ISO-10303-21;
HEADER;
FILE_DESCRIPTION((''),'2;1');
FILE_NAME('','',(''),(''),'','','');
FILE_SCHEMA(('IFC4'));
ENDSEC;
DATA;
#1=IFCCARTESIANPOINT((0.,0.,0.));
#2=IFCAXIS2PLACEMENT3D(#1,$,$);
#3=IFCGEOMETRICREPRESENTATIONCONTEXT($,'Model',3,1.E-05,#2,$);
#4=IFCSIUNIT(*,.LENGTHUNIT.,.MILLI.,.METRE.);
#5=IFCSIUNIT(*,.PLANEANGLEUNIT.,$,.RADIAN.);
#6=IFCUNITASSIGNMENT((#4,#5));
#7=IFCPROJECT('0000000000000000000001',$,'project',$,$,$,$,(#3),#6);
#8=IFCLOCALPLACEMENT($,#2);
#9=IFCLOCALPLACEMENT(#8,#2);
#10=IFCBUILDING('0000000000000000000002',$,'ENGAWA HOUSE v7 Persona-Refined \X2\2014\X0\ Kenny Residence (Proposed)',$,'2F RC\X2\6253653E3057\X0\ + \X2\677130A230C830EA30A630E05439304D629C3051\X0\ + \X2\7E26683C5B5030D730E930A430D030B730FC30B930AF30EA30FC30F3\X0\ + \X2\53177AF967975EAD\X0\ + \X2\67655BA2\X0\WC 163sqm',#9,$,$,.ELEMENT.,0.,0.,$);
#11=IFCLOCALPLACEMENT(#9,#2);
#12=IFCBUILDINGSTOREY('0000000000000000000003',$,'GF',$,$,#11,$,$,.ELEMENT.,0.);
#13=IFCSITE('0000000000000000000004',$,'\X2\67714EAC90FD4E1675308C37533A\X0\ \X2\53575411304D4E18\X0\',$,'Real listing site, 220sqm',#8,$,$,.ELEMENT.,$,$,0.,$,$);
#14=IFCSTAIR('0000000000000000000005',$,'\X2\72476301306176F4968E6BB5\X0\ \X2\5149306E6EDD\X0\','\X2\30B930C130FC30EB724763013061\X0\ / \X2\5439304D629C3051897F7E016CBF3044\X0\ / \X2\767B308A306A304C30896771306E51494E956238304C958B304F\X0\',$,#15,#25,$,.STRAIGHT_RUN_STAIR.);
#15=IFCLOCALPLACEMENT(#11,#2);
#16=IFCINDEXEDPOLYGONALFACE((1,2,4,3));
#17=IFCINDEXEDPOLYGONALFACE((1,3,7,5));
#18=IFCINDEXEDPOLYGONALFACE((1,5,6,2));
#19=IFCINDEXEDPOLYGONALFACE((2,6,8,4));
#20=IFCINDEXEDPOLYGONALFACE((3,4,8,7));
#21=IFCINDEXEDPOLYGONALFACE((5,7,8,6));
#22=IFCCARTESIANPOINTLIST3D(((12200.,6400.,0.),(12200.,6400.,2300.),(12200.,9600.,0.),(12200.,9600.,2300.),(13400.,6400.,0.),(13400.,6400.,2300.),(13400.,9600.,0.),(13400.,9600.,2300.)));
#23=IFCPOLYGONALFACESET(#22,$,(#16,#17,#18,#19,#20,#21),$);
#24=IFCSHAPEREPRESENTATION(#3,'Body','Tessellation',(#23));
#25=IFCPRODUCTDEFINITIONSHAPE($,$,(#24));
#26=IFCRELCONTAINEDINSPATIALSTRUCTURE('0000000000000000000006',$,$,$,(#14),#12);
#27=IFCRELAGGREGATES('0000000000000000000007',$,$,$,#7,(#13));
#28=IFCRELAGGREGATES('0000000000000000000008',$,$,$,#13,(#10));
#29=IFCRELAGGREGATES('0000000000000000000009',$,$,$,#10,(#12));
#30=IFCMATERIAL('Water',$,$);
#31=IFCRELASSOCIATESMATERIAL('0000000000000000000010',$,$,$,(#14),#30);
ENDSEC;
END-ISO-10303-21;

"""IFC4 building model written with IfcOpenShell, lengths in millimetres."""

from ifc_helpers import new_model, si_unit, frame, frame_2d, origin, place, context, project, spatial, rectangle, extrude, material, element, save


model = new_model("IFC4")

# Units and contexts
model_context = context("Model", 3, precision=1e-05, world=origin())
ifc_project = project(units=[si_unit("LENGTHUNIT", "METRE", prefix="MILLI"), si_unit("PLANEANGLEUNIT", "RADIAN")], contexts=[model_context])

# Site, building, storey
site_placement = place(None, origin())
site = spatial("IfcSite", under=ifc_project, at=site_placement, Name="東京都世田谷区 南向き丘", ObjectType="Real listing site, 220sqm", CompositionType="ELEMENT", RefElevation=0.0)
building_placement = place(site_placement, origin())
building = spatial("IfcBuilding", under=site, at=building_placement, Name="ENGAWA HOUSE v7 Persona-Refined — Kenny Residence (Proposed)", ObjectType="2F RC打放し + 東アトリウム吹き抜け + 縦格子プライバシースクリーン + 北竹林庭 + 来客WC 163sqm", CompositionType="ELEMENT", ElevationOfRefHeight=0.0, ElevationOfTerrain=0.0)
storey_placement = place(building_placement, origin())
storey = spatial("IfcBuildingStorey", under=building, at=storey_placement, Name="GF", CompositionType="ELEMENT", Elevation=0.0)

# Stair
ifc_material_1 = material(Name="Water")
stair_placement = place(storey_placement, frame((6100.0, 3200.0, 0.0)))
element("IfcStair", 1, at=stair_placement, inside=storey, material=ifc_material_1, Name="片持ち直階段 光の滝", Description="スチール片持ち / 吹き抜け西縁沿い / 登りながら東の光井戸が開く", PredefinedType="STRAIGHT_RUN_STAIR", context=model_context, shape_type="SweptSolid", body=[
    extrude(rectangle(XDim=1200.0, YDim=3200.0, at=frame_2d((600.0, 1600.0))), frame((6100.0, 3200.0, 0.0)), (0.0, 0.0, 1.0), 2300.0),
])

save(model, "model.ifc")
